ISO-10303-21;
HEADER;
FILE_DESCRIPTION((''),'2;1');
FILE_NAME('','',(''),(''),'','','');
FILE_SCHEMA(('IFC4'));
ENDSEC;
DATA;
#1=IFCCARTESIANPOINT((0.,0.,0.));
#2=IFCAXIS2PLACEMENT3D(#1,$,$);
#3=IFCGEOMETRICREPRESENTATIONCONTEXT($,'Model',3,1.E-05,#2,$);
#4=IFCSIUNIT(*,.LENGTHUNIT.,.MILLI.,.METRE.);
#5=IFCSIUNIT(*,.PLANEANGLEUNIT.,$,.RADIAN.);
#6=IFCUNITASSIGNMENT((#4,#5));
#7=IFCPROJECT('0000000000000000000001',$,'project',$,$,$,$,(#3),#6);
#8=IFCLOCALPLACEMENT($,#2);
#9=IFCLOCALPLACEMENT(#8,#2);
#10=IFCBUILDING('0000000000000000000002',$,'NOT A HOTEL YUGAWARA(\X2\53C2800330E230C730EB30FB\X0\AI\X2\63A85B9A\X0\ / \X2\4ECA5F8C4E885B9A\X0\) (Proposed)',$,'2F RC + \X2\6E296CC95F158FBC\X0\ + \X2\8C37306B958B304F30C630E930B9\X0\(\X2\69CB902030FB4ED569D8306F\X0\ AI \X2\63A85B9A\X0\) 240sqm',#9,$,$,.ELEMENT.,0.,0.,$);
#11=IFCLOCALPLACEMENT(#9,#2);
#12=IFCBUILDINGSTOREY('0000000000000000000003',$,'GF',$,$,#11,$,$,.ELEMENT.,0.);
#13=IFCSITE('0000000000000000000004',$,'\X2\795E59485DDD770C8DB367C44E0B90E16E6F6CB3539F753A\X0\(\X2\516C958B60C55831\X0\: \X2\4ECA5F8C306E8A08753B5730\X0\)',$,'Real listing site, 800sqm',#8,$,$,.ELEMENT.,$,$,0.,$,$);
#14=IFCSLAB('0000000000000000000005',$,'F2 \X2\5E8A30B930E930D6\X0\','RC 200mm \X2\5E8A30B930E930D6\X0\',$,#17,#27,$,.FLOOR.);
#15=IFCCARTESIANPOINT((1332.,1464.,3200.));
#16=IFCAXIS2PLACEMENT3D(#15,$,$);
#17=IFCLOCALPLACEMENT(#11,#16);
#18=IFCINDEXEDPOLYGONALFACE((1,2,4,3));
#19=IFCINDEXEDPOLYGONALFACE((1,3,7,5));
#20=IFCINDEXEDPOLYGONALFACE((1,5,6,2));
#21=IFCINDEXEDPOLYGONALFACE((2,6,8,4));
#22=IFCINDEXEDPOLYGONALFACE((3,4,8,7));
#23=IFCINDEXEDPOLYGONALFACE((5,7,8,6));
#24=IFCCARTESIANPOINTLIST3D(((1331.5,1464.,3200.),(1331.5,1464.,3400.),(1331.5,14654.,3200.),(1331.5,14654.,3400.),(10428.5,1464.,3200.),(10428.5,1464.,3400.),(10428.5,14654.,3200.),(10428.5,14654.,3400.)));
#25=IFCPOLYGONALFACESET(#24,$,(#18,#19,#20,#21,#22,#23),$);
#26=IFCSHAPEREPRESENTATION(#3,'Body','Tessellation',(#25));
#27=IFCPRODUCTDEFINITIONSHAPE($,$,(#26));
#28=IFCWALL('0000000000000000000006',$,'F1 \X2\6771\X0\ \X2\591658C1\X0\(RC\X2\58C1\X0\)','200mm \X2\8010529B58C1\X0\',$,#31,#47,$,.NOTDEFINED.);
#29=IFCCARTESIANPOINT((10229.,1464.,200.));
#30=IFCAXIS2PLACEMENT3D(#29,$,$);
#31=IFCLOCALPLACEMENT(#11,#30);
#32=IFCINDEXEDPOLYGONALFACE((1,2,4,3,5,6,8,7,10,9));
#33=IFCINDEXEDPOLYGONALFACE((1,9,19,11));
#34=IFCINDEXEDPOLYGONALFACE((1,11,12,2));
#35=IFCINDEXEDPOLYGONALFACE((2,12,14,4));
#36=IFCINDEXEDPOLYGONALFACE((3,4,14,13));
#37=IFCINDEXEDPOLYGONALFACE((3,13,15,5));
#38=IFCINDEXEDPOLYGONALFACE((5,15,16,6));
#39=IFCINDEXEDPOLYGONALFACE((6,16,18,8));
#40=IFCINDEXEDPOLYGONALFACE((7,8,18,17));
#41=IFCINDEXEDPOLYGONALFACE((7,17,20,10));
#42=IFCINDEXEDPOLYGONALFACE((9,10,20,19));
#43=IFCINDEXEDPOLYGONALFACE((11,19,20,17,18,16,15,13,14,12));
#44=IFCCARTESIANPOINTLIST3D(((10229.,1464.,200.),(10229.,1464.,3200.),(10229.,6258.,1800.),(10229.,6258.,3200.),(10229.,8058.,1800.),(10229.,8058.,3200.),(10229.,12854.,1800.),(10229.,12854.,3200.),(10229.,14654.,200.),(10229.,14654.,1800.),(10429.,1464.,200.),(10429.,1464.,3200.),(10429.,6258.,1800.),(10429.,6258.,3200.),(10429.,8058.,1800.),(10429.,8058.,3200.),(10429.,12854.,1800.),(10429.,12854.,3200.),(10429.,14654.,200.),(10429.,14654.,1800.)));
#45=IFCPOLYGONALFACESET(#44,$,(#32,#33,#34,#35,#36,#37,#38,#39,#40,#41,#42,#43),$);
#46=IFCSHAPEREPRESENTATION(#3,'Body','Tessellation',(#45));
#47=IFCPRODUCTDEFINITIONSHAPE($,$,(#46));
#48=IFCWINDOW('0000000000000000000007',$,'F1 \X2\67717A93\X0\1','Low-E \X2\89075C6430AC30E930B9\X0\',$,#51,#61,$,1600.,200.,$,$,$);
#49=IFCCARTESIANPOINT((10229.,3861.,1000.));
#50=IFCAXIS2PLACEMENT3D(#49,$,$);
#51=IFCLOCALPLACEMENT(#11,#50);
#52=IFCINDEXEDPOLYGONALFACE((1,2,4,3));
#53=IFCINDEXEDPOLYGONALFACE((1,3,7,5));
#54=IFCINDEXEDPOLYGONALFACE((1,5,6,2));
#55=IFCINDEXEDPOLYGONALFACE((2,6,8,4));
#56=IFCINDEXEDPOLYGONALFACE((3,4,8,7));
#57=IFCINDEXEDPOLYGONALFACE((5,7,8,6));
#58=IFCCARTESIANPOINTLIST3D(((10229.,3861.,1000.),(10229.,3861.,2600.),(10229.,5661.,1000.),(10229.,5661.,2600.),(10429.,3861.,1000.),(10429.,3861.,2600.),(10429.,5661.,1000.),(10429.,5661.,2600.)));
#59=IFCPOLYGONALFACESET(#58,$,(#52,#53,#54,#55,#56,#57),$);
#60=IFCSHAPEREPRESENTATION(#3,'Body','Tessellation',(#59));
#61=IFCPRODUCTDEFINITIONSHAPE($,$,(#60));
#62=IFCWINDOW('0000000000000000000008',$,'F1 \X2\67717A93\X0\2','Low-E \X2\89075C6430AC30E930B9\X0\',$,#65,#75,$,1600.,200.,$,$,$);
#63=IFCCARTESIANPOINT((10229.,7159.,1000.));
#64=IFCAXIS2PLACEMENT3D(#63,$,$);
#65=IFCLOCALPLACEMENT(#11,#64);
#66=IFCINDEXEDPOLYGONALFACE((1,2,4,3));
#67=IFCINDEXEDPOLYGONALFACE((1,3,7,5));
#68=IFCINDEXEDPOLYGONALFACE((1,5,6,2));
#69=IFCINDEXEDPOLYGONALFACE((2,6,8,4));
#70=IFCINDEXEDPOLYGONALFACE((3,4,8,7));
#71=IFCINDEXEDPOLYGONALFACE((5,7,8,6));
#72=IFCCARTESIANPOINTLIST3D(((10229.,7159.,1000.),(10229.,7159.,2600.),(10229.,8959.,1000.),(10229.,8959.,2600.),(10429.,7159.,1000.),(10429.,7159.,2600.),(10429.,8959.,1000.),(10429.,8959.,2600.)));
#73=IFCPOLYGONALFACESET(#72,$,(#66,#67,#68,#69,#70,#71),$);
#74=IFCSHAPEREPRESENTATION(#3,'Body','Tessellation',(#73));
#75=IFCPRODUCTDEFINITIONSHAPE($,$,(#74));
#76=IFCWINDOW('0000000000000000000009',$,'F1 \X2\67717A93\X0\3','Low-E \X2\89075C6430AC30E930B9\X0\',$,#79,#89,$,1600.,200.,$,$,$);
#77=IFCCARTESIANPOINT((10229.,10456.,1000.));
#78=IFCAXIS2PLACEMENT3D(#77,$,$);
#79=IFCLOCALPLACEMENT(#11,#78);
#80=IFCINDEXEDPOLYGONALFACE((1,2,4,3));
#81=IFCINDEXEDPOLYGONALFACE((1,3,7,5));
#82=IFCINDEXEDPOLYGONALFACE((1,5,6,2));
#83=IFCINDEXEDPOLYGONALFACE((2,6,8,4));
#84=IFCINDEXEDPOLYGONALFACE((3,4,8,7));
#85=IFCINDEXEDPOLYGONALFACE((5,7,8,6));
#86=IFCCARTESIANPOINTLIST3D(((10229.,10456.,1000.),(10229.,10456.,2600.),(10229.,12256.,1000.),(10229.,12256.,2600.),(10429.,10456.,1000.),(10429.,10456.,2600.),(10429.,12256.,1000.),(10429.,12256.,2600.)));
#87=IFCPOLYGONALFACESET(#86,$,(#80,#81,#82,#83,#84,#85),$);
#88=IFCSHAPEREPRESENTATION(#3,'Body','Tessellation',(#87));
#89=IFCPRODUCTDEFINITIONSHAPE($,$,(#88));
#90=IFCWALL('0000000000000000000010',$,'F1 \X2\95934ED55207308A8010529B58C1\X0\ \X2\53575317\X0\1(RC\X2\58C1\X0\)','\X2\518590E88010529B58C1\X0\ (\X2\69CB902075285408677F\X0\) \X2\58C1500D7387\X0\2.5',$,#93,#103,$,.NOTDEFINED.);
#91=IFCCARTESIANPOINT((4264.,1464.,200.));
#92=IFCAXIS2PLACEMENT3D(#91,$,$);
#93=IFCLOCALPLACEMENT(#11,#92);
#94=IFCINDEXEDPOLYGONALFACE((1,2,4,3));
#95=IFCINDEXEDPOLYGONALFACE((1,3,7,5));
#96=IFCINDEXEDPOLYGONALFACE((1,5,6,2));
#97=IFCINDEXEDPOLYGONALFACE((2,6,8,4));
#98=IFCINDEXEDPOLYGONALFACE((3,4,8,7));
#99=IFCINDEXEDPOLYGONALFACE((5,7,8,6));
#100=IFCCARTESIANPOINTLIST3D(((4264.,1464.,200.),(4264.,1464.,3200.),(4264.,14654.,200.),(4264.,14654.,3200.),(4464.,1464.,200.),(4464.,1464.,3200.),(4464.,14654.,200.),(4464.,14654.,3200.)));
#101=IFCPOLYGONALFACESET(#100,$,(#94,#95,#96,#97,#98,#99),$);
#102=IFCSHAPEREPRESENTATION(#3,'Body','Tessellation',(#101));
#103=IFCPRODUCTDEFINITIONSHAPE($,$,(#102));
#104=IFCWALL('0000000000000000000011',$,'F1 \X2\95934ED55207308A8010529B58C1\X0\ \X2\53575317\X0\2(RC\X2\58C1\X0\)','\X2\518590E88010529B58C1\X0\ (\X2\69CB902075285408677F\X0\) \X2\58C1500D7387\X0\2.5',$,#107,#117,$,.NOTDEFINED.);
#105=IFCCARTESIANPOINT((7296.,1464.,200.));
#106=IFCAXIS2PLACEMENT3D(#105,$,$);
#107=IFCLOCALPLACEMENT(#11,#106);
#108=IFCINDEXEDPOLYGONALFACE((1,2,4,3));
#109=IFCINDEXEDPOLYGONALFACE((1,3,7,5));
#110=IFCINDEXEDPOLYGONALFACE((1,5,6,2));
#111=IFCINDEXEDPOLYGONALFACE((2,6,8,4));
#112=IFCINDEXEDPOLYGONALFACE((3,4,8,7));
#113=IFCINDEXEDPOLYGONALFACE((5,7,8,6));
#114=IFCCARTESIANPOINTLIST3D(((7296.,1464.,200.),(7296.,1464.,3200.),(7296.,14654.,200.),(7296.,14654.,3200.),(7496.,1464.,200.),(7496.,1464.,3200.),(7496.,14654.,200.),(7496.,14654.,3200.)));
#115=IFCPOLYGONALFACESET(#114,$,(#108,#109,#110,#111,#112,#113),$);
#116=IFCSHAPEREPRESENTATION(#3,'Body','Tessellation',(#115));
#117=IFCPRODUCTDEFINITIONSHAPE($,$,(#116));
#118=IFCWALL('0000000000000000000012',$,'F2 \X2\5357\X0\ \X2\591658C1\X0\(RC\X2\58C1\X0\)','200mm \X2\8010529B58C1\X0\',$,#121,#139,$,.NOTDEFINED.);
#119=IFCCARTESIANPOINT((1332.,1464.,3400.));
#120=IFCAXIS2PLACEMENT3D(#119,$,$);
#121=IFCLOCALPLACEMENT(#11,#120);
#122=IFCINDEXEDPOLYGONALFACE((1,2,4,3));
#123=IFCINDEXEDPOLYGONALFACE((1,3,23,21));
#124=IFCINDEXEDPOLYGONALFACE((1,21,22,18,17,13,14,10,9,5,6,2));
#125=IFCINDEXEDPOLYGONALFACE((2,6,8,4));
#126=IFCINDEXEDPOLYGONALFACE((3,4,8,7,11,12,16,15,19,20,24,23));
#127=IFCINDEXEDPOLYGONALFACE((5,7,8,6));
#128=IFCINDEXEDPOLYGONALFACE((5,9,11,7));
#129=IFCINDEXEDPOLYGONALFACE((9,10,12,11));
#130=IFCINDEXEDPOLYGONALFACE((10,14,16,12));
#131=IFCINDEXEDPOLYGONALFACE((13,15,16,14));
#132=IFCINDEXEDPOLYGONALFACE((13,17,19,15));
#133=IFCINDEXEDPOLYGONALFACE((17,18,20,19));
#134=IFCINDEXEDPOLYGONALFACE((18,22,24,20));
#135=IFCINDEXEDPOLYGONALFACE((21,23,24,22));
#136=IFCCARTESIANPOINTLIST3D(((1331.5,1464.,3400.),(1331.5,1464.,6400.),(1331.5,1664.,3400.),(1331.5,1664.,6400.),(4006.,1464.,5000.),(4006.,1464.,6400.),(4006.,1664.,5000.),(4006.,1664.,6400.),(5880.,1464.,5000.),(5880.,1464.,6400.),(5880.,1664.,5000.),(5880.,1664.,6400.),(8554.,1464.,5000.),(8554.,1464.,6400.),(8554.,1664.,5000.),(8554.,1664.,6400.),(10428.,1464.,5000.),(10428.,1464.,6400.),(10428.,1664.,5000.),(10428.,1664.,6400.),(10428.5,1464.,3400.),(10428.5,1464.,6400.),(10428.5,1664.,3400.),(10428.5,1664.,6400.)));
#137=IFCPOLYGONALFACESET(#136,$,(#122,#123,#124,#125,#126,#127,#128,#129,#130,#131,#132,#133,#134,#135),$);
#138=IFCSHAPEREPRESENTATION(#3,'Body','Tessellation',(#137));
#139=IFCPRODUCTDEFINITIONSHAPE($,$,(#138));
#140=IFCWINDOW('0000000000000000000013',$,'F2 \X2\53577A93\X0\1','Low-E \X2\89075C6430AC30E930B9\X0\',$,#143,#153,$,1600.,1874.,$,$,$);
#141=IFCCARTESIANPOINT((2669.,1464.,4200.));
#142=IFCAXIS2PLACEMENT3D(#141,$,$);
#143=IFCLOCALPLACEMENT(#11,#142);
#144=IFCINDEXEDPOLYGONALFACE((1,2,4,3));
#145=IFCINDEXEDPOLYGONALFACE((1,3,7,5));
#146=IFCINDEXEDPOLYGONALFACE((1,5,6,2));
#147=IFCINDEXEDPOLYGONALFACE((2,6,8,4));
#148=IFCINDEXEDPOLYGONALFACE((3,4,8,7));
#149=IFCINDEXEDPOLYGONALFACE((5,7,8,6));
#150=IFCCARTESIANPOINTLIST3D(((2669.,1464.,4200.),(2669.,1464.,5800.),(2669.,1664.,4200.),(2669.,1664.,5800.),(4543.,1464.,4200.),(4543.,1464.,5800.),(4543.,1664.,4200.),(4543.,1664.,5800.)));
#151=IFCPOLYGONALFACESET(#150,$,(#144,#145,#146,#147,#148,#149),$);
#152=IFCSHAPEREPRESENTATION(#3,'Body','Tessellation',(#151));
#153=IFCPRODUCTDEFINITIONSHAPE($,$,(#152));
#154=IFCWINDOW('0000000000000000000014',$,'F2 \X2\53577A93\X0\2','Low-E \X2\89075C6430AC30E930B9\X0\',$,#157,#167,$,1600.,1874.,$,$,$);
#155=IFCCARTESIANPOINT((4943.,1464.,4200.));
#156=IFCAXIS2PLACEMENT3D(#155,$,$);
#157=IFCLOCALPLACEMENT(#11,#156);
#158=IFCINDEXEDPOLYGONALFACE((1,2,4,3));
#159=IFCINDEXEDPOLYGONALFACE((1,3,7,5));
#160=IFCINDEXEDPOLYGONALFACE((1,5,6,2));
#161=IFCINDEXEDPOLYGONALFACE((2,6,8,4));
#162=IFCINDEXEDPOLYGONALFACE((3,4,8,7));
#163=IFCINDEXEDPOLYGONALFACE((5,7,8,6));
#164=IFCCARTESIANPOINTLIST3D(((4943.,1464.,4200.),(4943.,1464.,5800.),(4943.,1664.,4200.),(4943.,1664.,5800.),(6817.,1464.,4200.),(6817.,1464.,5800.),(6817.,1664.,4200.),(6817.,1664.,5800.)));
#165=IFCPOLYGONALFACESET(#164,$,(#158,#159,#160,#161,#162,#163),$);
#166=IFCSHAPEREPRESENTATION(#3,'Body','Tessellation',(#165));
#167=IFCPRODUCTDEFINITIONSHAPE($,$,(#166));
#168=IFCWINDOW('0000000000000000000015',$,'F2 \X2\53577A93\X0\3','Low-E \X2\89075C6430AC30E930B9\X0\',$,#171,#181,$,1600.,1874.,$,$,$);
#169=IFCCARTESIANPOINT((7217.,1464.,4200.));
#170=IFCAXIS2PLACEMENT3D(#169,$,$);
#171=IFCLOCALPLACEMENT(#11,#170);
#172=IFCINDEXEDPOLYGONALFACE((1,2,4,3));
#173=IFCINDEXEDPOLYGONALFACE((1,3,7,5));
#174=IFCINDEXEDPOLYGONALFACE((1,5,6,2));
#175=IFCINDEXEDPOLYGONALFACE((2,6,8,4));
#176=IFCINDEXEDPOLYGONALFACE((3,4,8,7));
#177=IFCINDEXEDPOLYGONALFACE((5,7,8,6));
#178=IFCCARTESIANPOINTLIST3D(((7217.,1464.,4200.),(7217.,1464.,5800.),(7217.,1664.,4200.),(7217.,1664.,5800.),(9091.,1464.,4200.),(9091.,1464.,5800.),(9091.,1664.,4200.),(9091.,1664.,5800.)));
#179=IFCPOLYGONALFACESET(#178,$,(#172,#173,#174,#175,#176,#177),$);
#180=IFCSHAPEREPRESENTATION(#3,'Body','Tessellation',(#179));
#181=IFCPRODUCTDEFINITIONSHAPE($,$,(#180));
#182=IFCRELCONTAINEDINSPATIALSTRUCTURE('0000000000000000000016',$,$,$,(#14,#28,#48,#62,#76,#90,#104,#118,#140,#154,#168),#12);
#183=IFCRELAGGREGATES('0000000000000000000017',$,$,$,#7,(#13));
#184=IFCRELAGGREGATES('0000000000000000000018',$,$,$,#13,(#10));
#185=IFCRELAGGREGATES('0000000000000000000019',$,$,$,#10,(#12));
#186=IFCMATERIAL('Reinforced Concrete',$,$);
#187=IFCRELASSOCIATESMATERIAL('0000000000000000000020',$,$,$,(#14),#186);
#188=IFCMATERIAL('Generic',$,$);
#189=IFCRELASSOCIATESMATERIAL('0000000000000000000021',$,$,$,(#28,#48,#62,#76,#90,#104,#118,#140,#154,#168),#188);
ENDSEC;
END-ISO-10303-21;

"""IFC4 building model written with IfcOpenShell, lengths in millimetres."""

from ifc_helpers import new_model, si_unit, frame, frame_2d, origin, place, context, project, spatial, rectangle, extrude, material, element, fill, save


model = new_model("IFC4")

# Units and contexts
model_context = context("Model", 3, precision=1e-05, world=origin())
ifc_project = project(units=[si_unit("LENGTHUNIT", "METRE", prefix="MILLI"), si_unit("PLANEANGLEUNIT", "RADIAN")], contexts=[model_context])

# Site, building, storey
site_placement = place(None, origin())
site = spatial("IfcSite", under=ifc_project, at=site_placement, Name="神奈川県足柄下郡湯河原町(公開情報: 今後の計画地)", ObjectType="Real listing site, 800sqm", CompositionType="ELEMENT", RefElevation=0.0)
building_placement = place(site_placement, origin())
building = spatial("IfcBuilding", under=site, at=building_placement, Name="NOT A HOTEL YUGAWARA(参考モデル・AI推定 / 今後予定) (Proposed)", ObjectType="2F RC + 温泉引込 + 谷に開くテラス(構造・仕様は AI 推定) 240sqm", CompositionType="ELEMENT", ElevationOfRefHeight=0.0, ElevationOfTerrain=0.0)
storey_placement = place(building_placement, origin())
storey = spatial("IfcBuildingStorey", under=building, at=storey_placement, Name="GF", CompositionType="ELEMENT", Elevation=0.0)

# Slab
ifc_material_1 = material(Name="Reinforced Concrete")
slab_placement = place(storey_placement, frame((1332.0, 1464.0, 3200.0)))
element("IfcSlab", 1, at=slab_placement, inside=storey, material=ifc_material_1, Name="F2 床スラブ", Description="RC 200mm 床スラブ", PredefinedType="FLOOR", context=model_context, shape_type="SweptSolid", body=[
    extrude(rectangle(XDim=9097.0, YDim=13190.0, at=frame_2d((4548.0, 6595.0))), frame((1332.0, 1464.0, 3200.0)), (0.0, 0.0, 1.0), 200.0),
])

# Wall, openings, windows
ifc_material_2 = material(Name="Generic")
wall_1_placement = place(storey_placement, frame((10229.0, 1464.0, 200.0)))
wall_1 = element("IfcWall", 2, at=wall_1_placement, inside=storey, material=ifc_material_2, Name="F1 東 外壁(RC壁)", Description="200mm 耐力壁", PredefinedType="NOTDEFINED", context=model_context, shape_type="SweptSolid", body=[
    extrude(rectangle(XDim=200.0, YDim=13190.0, at=frame_2d((100.0, 6595.0))), frame((10229.0, 1464.0, 200.0)), (0.0, 0.0, 1.0), 3000.0),
])
opening_1_placement = place(storey_placement, frame((10229.0, 3861.0, 1000.0)))
opening_1 = element("IfcOpeningElement", 3, at=opening_1_placement, cuts=wall_1, PredefinedType="NOTDEFINED", context=model_context, shape_type="SweptSolid", body=[
    extrude(rectangle(XDim=200.0, YDim=1800.0, at=frame_2d((100.0, 900.0))), frame((10229.0, 3861.0, 1000.0)), (0.0, 0.0, 1.0), 1600.0),
])
opening_2_placement = place(storey_placement, frame((10229.0, 7159.0, 1000.0)))
opening_2 = element("IfcOpeningElement", 4, at=opening_2_placement, cuts=wall_1, PredefinedType="NOTDEFINED", context=model_context, shape_type="SweptSolid", body=[
    extrude(rectangle(XDim=200.0, YDim=1800.0, at=frame_2d((100.0, 900.0))), frame((10229.0, 7159.0, 1000.0)), (0.0, 0.0, 1.0), 1600.0),
])
opening_3_placement = place(storey_placement, frame((10229.0, 10456.0, 1000.0)))
opening_3 = element("IfcOpeningElement", 5, at=opening_3_placement, cuts=wall_1, PredefinedType="NOTDEFINED", context=model_context, shape_type="SweptSolid", body=[
    extrude(rectangle(XDim=200.0, YDim=1800.0, at=frame_2d((100.0, 900.0))), frame((10229.0, 10456.0, 1000.0)), (0.0, 0.0, 1.0), 1600.0),
])
window_1_placement = place(storey_placement, frame((10229.0, 3861.0, 1000.0)))
window_1 = element("IfcWindow", 6, at=window_1_placement, inside=storey, material=ifc_material_2, Name="F1 東窓1", Description="Low-E 複層ガラス", OverallHeight=1600.0, OverallWidth=200.0, context=model_context, shape_type="SweptSolid", body=[
    extrude(rectangle(XDim=200.0, YDim=1800.0, at=frame_2d((100.0, 900.0))), frame((10229.0, 3861.0, 1000.0)), (0.0, 0.0, 1.0), 1600.0),
])
fill(opening_1, window_1)
window_2_placement = place(storey_placement, frame((10229.0, 7159.0, 1000.0)))
window_2 = element("IfcWindow", 7, at=window_2_placement, inside=storey, material=ifc_material_2, Name="F1 東窓2", Description="Low-E 複層ガラス", OverallHeight=1600.0, OverallWidth=200.0, context=model_context, shape_type="SweptSolid", body=[
    extrude(rectangle(XDim=200.0, YDim=1800.0, at=frame_2d((100.0, 900.0))), frame((10229.0, 7159.0, 1000.0)), (0.0, 0.0, 1.0), 1600.0),
])
fill(opening_2, window_2)
window_3_placement = place(storey_placement, frame((10229.0, 10456.0, 1000.0)))
window_3 = element("IfcWindow", 8, at=window_3_placement, inside=storey, material=ifc_material_2, Name="F1 東窓3", Description="Low-E 複層ガラス", OverallHeight=1600.0, OverallWidth=200.0, context=model_context, shape_type="SweptSolid", body=[
    extrude(rectangle(XDim=200.0, YDim=1800.0, at=frame_2d((100.0, 900.0))), frame((10229.0, 10456.0, 1000.0)), (0.0, 0.0, 1.0), 1600.0),
])
fill(opening_3, window_3)

# Walls
wall_2_placement = place(storey_placement, frame((4264.0, 1464.0, 200.0)))
element("IfcWall", 9, at=wall_2_placement, inside=storey, material=ifc_material_2, Name="F1 間仕切り耐力壁 南北1(RC壁)", Description="内部耐力壁 (構造用合板) 壁倍率2.5", PredefinedType="NOTDEFINED", context=model_context, shape_type="SweptSolid", body=[
    extrude(rectangle(XDim=200.0, YDim=13190.0, at=frame_2d((100.0, 6595.0))), frame((4264.0, 1464.0, 200.0)), (0.0, 0.0, 1.0), 3000.0),
])
wall_3_placement = place(storey_placement, frame((7296.0, 1464.0, 200.0)))
element("IfcWall", 10, at=wall_3_placement, inside=storey, material=ifc_material_2, Name="F1 間仕切り耐力壁 南北2(RC壁)", Description="内部耐力壁 (構造用合板) 壁倍率2.5", PredefinedType="NOTDEFINED", context=model_context, shape_type="SweptSolid", body=[
    extrude(rectangle(XDim=200.0, YDim=13190.0, at=frame_2d((100.0, 6595.0))), frame((7296.0, 1464.0, 200.0)), (0.0, 0.0, 1.0), 3000.0),
])

# Wall, openings, windows
wall_4_placement = place(storey_placement, frame((1332.0, 1464.0, 3400.0)))
wall_4 = element("IfcWall", 11, at=wall_4_placement, inside=storey, material=ifc_material_2, Name="F2 南 外壁(RC壁)", Description="200mm 耐力壁", PredefinedType="NOTDEFINED", context=model_context, shape_type="SweptSolid", body=[
    extrude(rectangle(XDim=9097.0, YDim=200.0, at=frame_2d((4548.0, 100.0))), frame((1332.0, 1464.0, 3400.0)), (0.0, 0.0, 1.0), 3000.0),
])
opening_4_placement = place(storey_placement, frame((2669.0, 1464.0, 4200.0)))
opening_4 = element("IfcOpeningElement", 12, at=opening_4_placement, cuts=wall_4, PredefinedType="NOTDEFINED", context=model_context, shape_type="SweptSolid", body=[
    extrude(rectangle(XDim=1874.0, YDim=200.0, at=frame_2d((937.0, 100.0))), frame((2669.0, 1464.0, 4200.0)), (0.0, 0.0, 1.0), 1600.0),
])
opening_5_placement = place(storey_placement, frame((4943.0, 1464.0, 4200.0)))
opening_5 = element("IfcOpeningElement", 13, at=opening_5_placement, cuts=wall_4, PredefinedType="NOTDEFINED", context=model_context, shape_type="SweptSolid", body=[
    extrude(rectangle(XDim=1874.0, YDim=200.0, at=frame_2d((937.0, 100.0))), frame((4943.0, 1464.0, 4200.0)), (0.0, 0.0, 1.0), 1600.0),
])
opening_6_placement = place(storey_placement, frame((7217.0, 1464.0, 4200.0)))
opening_6 = element("IfcOpeningElement", 14, at=opening_6_placement, cuts=wall_4, PredefinedType="NOTDEFINED", context=model_context, shape_type="SweptSolid", body=[
    extrude(rectangle(XDim=1874.0, YDim=200.0, at=frame_2d((937.0, 100.0))), frame((7217.0, 1464.0, 4200.0)), (0.0, 0.0, 1.0), 1600.0),
])
window_4_placement = place(storey_placement, frame((2669.0, 1464.0, 4200.0)))
window_4 = element("IfcWindow", 15, at=window_4_placement, inside=storey, material=ifc_material_2, Name="F2 南窓1", Description="Low-E 複層ガラス", OverallHeight=1600.0, OverallWidth=1874.0, context=model_context, shape_type="SweptSolid", body=[
    extrude(rectangle(XDim=1874.0, YDim=200.0, at=frame_2d((937.0, 100.0))), frame((2669.0, 1464.0, 4200.0)), (0.0, 0.0, 1.0), 1600.0),
])
fill(opening_4, window_4)
window_5_placement = place(storey_placement, frame((4943.0, 1464.0, 4200.0)))
window_5 = element("IfcWindow", 16, at=window_5_placement, inside=storey, material=ifc_material_2, Name="F2 南窓2", Description="Low-E 複層ガラス", OverallHeight=1600.0, OverallWidth=1874.0, context=model_context, shape_type="SweptSolid", body=[
    extrude(rectangle(XDim=1874.0, YDim=200.0, at=frame_2d((937.0, 100.0))), frame((4943.0, 1464.0, 4200.0)), (0.0, 0.0, 1.0), 1600.0),
])
fill(opening_5, window_5)
window_6_placement = place(storey_placement, frame((7217.0, 1464.0, 4200.0)))
window_6 = element("IfcWindow", 17, at=window_6_placement, inside=storey, material=ifc_material_2, Name="F2 南窓3", Description="Low-E 複層ガラス", OverallHeight=1600.0, OverallWidth=1874.0, context=model_context, shape_type="SweptSolid", body=[
    extrude(rectangle(XDim=1874.0, YDim=200.0, at=frame_2d((937.0, 100.0))), frame((7217.0, 1464.0, 4200.0)), (0.0, 0.0, 1.0), 1600.0),
])
fill(opening_6, window_6)

save(model, "model.ifc")
